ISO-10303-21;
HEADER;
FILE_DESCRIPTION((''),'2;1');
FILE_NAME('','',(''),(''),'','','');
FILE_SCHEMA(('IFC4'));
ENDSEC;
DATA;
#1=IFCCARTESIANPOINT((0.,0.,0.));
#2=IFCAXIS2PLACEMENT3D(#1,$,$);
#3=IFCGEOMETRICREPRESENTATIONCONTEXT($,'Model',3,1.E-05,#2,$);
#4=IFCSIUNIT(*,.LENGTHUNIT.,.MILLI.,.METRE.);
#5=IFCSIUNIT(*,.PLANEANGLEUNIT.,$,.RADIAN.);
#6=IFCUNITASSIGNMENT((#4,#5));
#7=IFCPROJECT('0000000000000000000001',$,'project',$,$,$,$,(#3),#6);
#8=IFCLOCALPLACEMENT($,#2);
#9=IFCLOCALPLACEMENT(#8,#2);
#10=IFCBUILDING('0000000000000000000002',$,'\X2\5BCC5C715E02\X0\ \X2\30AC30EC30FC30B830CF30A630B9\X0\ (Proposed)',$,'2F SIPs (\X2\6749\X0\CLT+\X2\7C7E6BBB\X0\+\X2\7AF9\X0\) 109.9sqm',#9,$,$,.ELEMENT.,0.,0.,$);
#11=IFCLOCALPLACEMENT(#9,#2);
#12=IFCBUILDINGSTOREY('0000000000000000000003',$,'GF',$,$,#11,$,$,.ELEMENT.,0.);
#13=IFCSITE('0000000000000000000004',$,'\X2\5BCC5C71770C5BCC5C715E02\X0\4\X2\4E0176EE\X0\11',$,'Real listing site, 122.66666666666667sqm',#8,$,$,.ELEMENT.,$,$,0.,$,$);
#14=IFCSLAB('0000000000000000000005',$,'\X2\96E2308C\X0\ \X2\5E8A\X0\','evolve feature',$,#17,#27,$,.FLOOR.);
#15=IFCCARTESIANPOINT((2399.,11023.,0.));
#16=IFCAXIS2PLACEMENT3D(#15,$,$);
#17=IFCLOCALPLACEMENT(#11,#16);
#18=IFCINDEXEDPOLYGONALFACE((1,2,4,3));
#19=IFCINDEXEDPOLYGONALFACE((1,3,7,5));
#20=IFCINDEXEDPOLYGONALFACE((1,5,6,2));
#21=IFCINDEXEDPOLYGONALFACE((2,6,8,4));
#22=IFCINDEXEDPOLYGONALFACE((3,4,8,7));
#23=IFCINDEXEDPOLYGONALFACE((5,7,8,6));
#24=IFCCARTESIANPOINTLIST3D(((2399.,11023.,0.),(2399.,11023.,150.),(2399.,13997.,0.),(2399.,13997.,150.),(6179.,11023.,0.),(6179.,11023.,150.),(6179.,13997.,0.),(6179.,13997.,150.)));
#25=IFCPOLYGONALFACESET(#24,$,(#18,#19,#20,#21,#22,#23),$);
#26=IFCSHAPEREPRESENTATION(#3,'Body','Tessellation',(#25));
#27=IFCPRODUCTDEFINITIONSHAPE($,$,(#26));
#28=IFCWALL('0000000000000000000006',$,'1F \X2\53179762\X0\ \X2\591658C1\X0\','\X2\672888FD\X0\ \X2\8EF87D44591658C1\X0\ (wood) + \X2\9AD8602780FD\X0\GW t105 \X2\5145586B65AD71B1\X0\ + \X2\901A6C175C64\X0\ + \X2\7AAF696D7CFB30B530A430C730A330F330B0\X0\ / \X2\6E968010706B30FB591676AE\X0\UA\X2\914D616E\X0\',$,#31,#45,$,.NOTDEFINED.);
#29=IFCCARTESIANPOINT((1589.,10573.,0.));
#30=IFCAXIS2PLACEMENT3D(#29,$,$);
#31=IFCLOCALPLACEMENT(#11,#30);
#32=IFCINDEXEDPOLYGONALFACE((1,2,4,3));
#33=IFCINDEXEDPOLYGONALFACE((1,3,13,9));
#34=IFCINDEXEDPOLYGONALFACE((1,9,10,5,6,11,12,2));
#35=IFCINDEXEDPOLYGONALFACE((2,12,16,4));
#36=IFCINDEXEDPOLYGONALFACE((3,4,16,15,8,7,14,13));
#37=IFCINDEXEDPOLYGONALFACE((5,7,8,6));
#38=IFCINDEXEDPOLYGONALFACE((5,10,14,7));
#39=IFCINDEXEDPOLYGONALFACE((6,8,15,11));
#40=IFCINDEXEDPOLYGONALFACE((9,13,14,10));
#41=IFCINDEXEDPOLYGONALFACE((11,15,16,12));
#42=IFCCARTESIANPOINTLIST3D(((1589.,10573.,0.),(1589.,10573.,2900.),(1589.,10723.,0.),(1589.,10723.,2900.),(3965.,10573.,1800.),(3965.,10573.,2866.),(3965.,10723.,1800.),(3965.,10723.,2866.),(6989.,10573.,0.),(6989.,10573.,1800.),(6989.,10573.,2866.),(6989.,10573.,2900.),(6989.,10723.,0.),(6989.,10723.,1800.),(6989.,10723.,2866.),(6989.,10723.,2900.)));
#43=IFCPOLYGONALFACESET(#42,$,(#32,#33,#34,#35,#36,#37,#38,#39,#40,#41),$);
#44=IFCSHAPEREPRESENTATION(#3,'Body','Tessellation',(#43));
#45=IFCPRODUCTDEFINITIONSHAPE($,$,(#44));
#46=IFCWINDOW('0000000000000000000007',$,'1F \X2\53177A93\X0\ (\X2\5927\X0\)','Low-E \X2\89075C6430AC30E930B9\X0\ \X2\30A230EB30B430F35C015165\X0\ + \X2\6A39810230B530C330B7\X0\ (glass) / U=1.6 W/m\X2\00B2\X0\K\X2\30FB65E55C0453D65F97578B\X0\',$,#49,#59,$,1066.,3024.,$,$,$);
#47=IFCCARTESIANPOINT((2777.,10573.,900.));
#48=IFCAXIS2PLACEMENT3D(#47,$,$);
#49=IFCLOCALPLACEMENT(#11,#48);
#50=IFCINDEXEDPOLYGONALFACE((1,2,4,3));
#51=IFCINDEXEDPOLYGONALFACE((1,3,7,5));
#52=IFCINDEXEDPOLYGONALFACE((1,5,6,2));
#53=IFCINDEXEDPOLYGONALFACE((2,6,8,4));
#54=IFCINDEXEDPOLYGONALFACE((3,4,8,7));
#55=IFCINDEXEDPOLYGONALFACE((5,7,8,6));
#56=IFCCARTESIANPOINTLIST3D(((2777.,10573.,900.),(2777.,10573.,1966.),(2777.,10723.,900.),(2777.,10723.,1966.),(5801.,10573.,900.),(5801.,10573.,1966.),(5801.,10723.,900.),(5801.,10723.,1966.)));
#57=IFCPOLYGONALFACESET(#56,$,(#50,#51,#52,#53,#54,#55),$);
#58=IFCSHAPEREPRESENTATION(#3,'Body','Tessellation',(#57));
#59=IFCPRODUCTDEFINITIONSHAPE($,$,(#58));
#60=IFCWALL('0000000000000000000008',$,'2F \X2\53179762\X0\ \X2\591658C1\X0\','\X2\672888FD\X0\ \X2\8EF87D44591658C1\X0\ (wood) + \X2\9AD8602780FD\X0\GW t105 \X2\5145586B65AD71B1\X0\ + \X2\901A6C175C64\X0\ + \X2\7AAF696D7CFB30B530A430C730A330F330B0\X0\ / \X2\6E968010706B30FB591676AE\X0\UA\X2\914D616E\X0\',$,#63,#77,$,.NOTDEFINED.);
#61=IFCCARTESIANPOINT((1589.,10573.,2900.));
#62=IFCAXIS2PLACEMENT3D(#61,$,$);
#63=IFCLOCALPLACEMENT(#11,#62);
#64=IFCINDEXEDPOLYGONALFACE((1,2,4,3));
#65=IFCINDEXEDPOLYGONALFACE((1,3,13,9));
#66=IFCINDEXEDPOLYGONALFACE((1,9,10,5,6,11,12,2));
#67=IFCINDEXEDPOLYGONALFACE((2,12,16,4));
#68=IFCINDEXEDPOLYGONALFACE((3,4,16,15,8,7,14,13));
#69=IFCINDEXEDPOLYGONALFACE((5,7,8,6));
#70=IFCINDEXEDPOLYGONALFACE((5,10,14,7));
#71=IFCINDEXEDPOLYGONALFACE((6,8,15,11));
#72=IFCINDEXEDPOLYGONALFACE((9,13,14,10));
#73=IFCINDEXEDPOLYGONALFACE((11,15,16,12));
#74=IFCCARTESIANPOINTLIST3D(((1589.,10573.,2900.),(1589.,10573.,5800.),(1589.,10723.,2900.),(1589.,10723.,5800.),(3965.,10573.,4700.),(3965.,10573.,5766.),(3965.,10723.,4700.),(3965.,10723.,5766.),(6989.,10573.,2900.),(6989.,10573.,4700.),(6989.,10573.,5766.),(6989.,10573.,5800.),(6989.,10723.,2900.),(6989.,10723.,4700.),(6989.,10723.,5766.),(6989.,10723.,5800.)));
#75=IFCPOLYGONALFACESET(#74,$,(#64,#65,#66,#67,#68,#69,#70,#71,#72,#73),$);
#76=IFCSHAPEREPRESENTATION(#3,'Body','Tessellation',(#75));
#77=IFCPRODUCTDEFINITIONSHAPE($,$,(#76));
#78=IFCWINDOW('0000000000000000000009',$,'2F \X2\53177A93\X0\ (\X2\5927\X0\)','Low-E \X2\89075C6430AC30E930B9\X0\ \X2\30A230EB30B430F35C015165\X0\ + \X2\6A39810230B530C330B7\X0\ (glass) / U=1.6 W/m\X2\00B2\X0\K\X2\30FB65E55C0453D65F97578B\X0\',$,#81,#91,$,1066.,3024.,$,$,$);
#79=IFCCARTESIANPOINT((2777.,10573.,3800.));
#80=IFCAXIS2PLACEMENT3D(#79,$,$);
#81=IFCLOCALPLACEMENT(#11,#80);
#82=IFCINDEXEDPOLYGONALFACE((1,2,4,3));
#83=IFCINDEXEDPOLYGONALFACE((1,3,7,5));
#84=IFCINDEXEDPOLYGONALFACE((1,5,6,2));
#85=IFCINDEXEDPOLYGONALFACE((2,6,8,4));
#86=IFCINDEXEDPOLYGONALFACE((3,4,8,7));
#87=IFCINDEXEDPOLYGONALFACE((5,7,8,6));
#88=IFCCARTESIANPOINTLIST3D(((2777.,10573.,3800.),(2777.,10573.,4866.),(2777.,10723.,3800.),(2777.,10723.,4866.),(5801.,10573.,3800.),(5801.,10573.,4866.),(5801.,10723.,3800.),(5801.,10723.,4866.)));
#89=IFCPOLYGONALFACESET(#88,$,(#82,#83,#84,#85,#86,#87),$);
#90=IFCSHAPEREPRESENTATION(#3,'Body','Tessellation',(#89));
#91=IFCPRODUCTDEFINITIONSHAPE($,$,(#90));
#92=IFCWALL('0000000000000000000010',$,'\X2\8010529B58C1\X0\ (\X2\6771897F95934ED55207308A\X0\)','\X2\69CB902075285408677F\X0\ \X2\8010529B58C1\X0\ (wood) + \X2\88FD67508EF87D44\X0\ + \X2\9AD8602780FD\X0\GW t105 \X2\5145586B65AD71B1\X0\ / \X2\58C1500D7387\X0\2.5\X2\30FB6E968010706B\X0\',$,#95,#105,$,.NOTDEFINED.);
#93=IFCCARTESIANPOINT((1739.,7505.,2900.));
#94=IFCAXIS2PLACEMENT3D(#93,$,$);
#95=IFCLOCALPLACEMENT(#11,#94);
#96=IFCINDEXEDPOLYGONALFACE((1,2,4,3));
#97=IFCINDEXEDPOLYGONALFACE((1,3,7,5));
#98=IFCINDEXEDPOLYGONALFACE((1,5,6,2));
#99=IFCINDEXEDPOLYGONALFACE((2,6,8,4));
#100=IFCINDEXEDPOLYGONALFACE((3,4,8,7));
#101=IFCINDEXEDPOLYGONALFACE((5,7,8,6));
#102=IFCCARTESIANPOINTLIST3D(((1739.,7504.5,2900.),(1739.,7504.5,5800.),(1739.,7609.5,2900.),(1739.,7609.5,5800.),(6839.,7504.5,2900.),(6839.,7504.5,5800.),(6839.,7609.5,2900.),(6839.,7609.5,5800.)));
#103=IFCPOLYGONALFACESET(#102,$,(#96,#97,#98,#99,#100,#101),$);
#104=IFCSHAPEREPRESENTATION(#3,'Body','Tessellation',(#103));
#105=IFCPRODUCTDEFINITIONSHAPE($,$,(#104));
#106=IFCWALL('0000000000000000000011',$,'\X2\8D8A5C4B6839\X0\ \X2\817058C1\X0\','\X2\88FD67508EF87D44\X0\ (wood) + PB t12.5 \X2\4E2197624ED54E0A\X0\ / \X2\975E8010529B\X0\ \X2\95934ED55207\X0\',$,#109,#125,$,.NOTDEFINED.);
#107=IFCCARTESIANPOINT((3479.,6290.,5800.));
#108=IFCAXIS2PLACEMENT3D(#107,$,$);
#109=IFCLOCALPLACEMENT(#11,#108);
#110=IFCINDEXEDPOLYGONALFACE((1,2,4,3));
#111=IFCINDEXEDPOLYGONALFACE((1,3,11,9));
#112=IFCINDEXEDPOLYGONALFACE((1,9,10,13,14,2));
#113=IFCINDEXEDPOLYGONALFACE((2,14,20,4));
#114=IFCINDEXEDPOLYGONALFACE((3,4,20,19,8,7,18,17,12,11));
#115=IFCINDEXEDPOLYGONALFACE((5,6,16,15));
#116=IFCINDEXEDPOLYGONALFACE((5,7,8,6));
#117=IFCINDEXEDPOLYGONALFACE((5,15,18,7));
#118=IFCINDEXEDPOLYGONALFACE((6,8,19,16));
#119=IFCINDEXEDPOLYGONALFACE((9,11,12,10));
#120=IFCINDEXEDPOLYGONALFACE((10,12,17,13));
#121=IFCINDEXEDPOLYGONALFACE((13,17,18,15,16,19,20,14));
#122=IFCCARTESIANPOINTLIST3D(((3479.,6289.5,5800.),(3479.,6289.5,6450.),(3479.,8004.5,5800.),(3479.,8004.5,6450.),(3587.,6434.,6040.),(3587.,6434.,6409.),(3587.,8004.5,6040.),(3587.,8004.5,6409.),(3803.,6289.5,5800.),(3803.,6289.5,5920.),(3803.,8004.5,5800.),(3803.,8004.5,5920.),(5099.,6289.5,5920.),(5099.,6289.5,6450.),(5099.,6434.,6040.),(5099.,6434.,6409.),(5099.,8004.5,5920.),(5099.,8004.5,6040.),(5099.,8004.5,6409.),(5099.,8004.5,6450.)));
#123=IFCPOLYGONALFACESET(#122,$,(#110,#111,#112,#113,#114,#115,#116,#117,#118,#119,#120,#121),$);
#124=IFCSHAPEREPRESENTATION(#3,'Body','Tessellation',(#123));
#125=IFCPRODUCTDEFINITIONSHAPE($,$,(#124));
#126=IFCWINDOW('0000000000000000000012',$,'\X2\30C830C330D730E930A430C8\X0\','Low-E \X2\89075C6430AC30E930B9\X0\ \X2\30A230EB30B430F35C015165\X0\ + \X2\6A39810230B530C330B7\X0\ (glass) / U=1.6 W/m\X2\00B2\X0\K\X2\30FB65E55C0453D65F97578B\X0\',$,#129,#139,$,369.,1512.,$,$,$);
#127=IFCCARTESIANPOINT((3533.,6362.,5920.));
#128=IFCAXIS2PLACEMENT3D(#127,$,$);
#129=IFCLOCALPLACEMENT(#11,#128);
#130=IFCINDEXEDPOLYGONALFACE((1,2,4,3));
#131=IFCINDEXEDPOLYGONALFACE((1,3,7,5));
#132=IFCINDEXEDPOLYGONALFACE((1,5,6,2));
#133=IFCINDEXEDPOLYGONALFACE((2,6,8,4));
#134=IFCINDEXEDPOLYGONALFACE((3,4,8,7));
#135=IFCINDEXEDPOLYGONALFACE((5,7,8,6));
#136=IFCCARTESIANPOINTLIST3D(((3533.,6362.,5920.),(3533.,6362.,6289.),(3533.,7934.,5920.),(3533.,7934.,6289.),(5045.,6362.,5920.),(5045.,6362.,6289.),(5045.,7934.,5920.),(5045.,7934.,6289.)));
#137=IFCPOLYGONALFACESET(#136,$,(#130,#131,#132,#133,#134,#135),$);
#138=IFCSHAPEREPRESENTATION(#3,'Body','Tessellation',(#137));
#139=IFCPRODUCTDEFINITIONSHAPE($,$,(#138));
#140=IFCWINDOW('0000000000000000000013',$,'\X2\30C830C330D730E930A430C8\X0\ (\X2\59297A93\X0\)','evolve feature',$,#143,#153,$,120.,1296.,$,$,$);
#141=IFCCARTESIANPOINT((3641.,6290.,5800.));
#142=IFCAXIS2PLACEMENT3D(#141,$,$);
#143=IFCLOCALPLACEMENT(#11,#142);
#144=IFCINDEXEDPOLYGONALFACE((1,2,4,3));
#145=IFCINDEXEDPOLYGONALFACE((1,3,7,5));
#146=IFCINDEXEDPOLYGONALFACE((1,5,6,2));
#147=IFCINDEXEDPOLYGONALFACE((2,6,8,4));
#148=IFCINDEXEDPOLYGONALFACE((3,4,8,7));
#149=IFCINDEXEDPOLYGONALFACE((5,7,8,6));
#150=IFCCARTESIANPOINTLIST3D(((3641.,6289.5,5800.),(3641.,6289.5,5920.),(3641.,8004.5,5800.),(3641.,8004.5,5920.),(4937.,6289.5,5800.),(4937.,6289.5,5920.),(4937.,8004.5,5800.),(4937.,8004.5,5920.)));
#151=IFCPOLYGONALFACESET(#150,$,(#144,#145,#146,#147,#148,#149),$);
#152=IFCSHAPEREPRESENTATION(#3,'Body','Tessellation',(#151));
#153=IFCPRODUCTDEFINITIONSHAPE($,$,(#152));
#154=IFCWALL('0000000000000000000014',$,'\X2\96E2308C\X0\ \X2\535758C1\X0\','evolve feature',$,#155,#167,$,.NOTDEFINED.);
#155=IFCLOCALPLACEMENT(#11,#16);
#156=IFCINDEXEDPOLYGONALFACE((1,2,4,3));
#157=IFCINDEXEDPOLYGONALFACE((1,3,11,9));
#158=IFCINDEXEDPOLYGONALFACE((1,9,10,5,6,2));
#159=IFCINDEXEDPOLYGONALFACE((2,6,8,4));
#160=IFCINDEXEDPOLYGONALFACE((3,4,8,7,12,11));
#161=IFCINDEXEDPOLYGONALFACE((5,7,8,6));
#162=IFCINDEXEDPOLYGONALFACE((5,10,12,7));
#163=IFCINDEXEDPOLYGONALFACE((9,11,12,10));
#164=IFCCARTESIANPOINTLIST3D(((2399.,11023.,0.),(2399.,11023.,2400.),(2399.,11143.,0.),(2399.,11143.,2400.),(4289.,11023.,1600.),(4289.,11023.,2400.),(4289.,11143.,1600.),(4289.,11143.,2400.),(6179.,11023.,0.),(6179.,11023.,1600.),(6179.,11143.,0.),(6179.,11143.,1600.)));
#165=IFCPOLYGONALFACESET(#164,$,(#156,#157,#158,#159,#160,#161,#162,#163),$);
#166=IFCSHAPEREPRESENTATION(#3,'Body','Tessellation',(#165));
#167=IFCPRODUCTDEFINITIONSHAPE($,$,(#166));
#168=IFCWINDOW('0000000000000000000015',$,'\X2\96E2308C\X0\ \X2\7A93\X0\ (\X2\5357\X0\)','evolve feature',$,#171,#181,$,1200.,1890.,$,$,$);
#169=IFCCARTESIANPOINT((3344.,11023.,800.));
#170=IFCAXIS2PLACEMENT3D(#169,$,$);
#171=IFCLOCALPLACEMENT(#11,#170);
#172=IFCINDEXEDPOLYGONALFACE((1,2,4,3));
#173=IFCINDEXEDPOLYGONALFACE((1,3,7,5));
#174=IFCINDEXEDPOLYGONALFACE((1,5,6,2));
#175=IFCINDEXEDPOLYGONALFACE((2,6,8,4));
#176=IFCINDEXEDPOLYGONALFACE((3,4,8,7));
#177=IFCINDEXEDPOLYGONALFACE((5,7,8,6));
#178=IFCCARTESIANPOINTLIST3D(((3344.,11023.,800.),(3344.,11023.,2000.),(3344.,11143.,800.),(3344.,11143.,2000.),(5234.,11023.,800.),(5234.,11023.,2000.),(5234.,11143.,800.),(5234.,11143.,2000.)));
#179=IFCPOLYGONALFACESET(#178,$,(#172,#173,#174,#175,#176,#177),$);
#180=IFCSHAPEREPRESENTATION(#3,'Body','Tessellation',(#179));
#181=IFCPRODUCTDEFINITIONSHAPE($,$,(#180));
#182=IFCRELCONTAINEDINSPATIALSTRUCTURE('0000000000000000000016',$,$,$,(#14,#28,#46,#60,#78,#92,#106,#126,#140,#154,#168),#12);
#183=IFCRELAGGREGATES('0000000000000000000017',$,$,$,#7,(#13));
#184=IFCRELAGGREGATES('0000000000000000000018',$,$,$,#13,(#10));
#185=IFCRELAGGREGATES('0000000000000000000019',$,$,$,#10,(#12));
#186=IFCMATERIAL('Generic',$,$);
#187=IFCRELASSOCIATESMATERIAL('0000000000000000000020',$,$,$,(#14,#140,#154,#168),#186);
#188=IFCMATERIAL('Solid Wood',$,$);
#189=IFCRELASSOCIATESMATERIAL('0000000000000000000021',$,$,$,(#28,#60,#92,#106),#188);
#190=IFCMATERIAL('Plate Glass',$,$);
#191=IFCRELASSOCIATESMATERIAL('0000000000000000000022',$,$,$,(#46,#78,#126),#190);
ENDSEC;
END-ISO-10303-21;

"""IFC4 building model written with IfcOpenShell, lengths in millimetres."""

from ifc_helpers import new_model, si_unit, frame, frame_2d, origin, place, context, project, spatial, rectangle, extrude, material, element, fill, save


model = new_model("IFC4")

# Units and contexts
model_context = context("Model", 3, precision=1e-05, world=origin())
ifc_project = project(units=[si_unit("LENGTHUNIT", "METRE", prefix="MILLI"), si_unit("PLANEANGLEUNIT", "RADIAN")], contexts=[model_context])

# Site, building, storey
site_placement = place(None, origin())
site = spatial("IfcSite", under=ifc_project, at=site_placement, Name="富山県富山市4丁目11", ObjectType="Real listing site, 122.66666666666667sqm", CompositionType="ELEMENT", RefElevation=0.0)
building_placement = place(site_placement, origin())
building = spatial("IfcBuilding", under=site, at=building_placement, Name="富山市 ガレージハウス (Proposed)", ObjectType="2F SIPs (杉CLT+籾殻+竹) 109.9sqm", CompositionType="ELEMENT", ElevationOfRefHeight=0.0, ElevationOfTerrain=0.0)
storey_placement = place(building_placement, origin())
storey = spatial("IfcBuildingStorey", under=building, at=storey_placement, Name="GF", CompositionType="ELEMENT", Elevation=0.0)

# Slab
ifc_material_1 = material(Name="Generic")
slab_placement = place(storey_placement, frame((2399.0, 11023.0, 0.0)))
element("IfcSlab", 1, at=slab_placement, inside=storey, material=ifc_material_1, Name="離れ 床", Description="evolve feature", PredefinedType="FLOOR", context=model_context, shape_type="SweptSolid", body=[
    extrude(rectangle(XDim=3780.0, YDim=2974.0, at=frame_2d((1890.0, 1487.0))), frame((2399.0, 11023.0, 0.0)), (0.0, 0.0, 1.0), 150.0),
])

# Wall, opening, window
ifc_material_2 = material(Name="Solid Wood")
wall_1_placement = place(storey_placement, frame((1589.0, 10573.0, 0.0)))
wall_1 = element("IfcWall", 2, at=wall_1_placement, inside=storey, material=ifc_material_2, Name="1F 北面 外壁", Description="木製 軸組外壁 (wood) + 高性能GW t105 充填断熱 + 通気層 + 窯業系サイディング / 準耐火・外皮UA配慮", PredefinedType="NOTDEFINED", context=model_context, shape_type="SweptSolid", body=[
    extrude(rectangle(XDim=5400.0, YDim=150.0, at=frame_2d((2700.0, 75.0))), frame((1589.0, 10573.0, 0.0)), (0.0, 0.0, 1.0), 2900.0),
])
opening_1_placement = place(storey_placement, frame((2777.0, 10573.0, 900.0)))
opening_1 = element("IfcOpeningElement", 3, at=opening_1_placement, cuts=wall_1, PredefinedType="NOTDEFINED", context=model_context, shape_type="SweptSolid", body=[
    extrude(rectangle(XDim=3024.0, YDim=150.0, at=frame_2d((1512.0, 75.0))), frame((2777.0, 10573.0, 900.0)), (0.0, 0.0, 1.0), 1066.0),
])
ifc_material_3 = material(Name="Plate Glass")
window_1_placement = place(storey_placement, frame((2777.0, 10573.0, 900.0)))
window_1 = element("IfcWindow", 4, at=window_1_placement, inside=storey, material=ifc_material_3, Name="1F 北窓 (大)", Description="Low-E 複層ガラス アルゴン封入 + 樹脂サッシ (glass) / U=1.6 W/m²K・日射取得型", OverallHeight=1066.0, OverallWidth=3024.0, context=model_context, shape_type="SweptSolid", body=[
    extrude(rectangle(XDim=3024.0, YDim=150.0, at=frame_2d((1512.0, 75.0))), frame((2777.0, 10573.0, 900.0)), (0.0, 0.0, 1.0), 1066.0),
])
fill(opening_1, window_1)

# Wall, opening, window
wall_2_placement = place(storey_placement, frame((1589.0, 10573.0, 2900.0)))
wall_2 = element("IfcWall", 5, at=wall_2_placement, inside=storey, material=ifc_material_2, Name="2F 北面 外壁", Description="木製 軸組外壁 (wood) + 高性能GW t105 充填断熱 + 通気層 + 窯業系サイディング / 準耐火・外皮UA配慮", PredefinedType="NOTDEFINED", context=model_context, shape_type="SweptSolid", body=[
    extrude(rectangle(XDim=5400.0, YDim=150.0, at=frame_2d((2700.0, 75.0))), frame((1589.0, 10573.0, 2900.0)), (0.0, 0.0, 1.0), 2900.0),
])
opening_2_placement = place(storey_placement, frame((2777.0, 10573.0, 3800.0)))
opening_2 = element("IfcOpeningElement", 6, at=opening_2_placement, cuts=wall_2, PredefinedType="NOTDEFINED", context=model_context, shape_type="SweptSolid", body=[
    extrude(rectangle(XDim=3024.0, YDim=150.0, at=frame_2d((1512.0, 75.0))), frame((2777.0, 10573.0, 3800.0)), (0.0, 0.0, 1.0), 1066.0),
])
window_2_placement = place(storey_placement, frame((2777.0, 10573.0, 3800.0)))
window_2 = element("IfcWindow", 7, at=window_2_placement, inside=storey, material=ifc_material_3, Name="2F 北窓 (大)", Description="Low-E 複層ガラス アルゴン封入 + 樹脂サッシ (glass) / U=1.6 W/m²K・日射取得型", OverallHeight=1066.0, OverallWidth=3024.0, context=model_context, shape_type="SweptSolid", body=[
    extrude(rectangle(XDim=3024.0, YDim=150.0, at=frame_2d((1512.0, 75.0))), frame((2777.0, 10573.0, 3800.0)), (0.0, 0.0, 1.0), 1066.0),
])
fill(opening_2, window_2)

# Wall
wall_3_placement = place(storey_placement, frame((1739.0, 7505.0, 2900.0)))
element("IfcWall", 8, at=wall_3_placement, inside=storey, material=ifc_material_2, Name="耐力壁 (東西間仕切り)", Description="構造用合板 耐力壁 (wood) + 製材軸組 + 高性能GW t105 充填断熱 / 壁倍率2.5・準耐火", PredefinedType="NOTDEFINED", context=model_context, shape_type="SweptSolid", body=[
    extrude(rectangle(XDim=5100.0, YDim=105.0, at=frame_2d((2550.0, 52.0))), frame((1739.0, 7505.0, 2900.0)), (0.0, 0.0, 1.0), 2900.0),
])

# Wall, openings, windows
wall_4_placement = place(storey_placement, frame((3479.0, 6290.0, 5800.0)))
wall_4 = element("IfcWall", 9, at=wall_4_placement, inside=storey, material=ifc_material_2, Name="越屋根 腰壁", Description="製材軸組 (wood) + PB t12.5 両面仕上 / 非耐力 間仕切", PredefinedType="NOTDEFINED", context=model_context, shape_type="SweptSolid", body=[
    extrude(rectangle(XDim=1620.0, YDim=1715.0, at=frame_2d((810.0, 857.0))), frame((3479.0, 6290.0, 5800.0)), (0.0, 0.0, 1.0), 650.0),
])
opening_3_placement = place(storey_placement, frame((3533.0, 6362.0, 5920.0)))
opening_3 = element("IfcOpeningElement", 10, at=opening_3_placement, cuts=wall_4, PredefinedType="NOTDEFINED", context=model_context, shape_type="SweptSolid", body=[
    extrude(rectangle(XDim=1512.0, YDim=1572.0, at=frame_2d((756.0, 786.0))), frame((3533.0, 6362.0, 5920.0)), (0.0, 0.0, 1.0), 369.0),
])
opening_4_placement = place(storey_placement, frame((3641.0, 6290.0, 5800.0)))
opening_4 = element("IfcOpeningElement", 11, at=opening_4_placement, cuts=wall_4, PredefinedType="NOTDEFINED", context=model_context, shape_type="SweptSolid", body=[
    extrude(rectangle(XDim=1296.0, YDim=1715.0, at=frame_2d((648.0, 857.0))), frame((3641.0, 6290.0, 5800.0)), (0.0, 0.0, 1.0), 120.0),
])
window_3_placement = place(storey_placement, frame((3533.0, 6362.0, 5920.0)))
window_3 = element("IfcWindow", 12, at=window_3_placement, inside=storey, material=ifc_material_3, Name="トップライト", Description="Low-E 複層ガラス アルゴン封入 + 樹脂サッシ (glass) / U=1.6 W/m²K・日射取得型", OverallHeight=369.0, OverallWidth=1512.0, context=model_context, shape_type="SweptSolid", body=[
    extrude(rectangle(XDim=1512.0, YDim=1572.0, at=frame_2d((756.0, 786.0))), frame((3533.0, 6362.0, 5920.0)), (0.0, 0.0, 1.0), 369.0),
])
fill(opening_3, window_3)
window_4_placement = place(storey_placement, frame((3641.0, 6290.0, 5800.0)))
window_4 = element("IfcWindow", 13, at=window_4_placement, inside=storey, material=ifc_material_1, Name="トップライト (天窓)", Description="evolve feature", OverallHeight=120.0, OverallWidth=1296.0, context=model_context, shape_type="SweptSolid", body=[
    extrude(rectangle(XDim=1296.0, YDim=1715.0, at=frame_2d((648.0, 857.0))), frame((3641.0, 6290.0, 5800.0)), (0.0, 0.0, 1.0), 120.0),
])
fill(opening_4, window_4)

# Wall, opening, window
wall_5_placement = place(storey_placement, frame((2399.0, 11023.0, 0.0)))
wall_5 = element("IfcWall", 14, at=wall_5_placement, inside=storey, material=ifc_material_1, Name="離れ 南壁", Description="evolve feature", PredefinedType="NOTDEFINED", context=model_context, shape_type="SweptSolid", body=[
    extrude(rectangle(XDim=3780.0, YDim=120.0, at=frame_2d((1890.0, 60.0))), frame((2399.0, 11023.0, 0.0)), (0.0, 0.0, 1.0), 2400.0),
])
opening_5_placement = place(storey_placement, frame((3344.0, 11023.0, 800.0)))
opening_5 = element("IfcOpeningElement", 15, at=opening_5_placement, cuts=wall_5, PredefinedType="NOTDEFINED", context=model_context, shape_type="SweptSolid", body=[
    extrude(rectangle(XDim=1890.0, YDim=120.0, at=frame_2d((945.0, 60.0))), frame((3344.0, 11023.0, 800.0)), (0.0, 0.0, 1.0), 1200.0),
])
window_5_placement = place(storey_placement, frame((3344.0, 11023.0, 800.0)))
window_5 = element("IfcWindow", 16, at=window_5_placement, inside=storey, material=ifc_material_1, Name="離れ 窓 (南)", Description="evolve feature", OverallHeight=1200.0, OverallWidth=1890.0, context=model_context, shape_type="SweptSolid", body=[
    extrude(rectangle(XDim=1890.0, YDim=120.0, at=frame_2d((945.0, 60.0))), frame((3344.0, 11023.0, 800.0)), (0.0, 0.0, 1.0), 1200.0),
])
fill(opening_5, window_5)

save(model, "model.ifc")
